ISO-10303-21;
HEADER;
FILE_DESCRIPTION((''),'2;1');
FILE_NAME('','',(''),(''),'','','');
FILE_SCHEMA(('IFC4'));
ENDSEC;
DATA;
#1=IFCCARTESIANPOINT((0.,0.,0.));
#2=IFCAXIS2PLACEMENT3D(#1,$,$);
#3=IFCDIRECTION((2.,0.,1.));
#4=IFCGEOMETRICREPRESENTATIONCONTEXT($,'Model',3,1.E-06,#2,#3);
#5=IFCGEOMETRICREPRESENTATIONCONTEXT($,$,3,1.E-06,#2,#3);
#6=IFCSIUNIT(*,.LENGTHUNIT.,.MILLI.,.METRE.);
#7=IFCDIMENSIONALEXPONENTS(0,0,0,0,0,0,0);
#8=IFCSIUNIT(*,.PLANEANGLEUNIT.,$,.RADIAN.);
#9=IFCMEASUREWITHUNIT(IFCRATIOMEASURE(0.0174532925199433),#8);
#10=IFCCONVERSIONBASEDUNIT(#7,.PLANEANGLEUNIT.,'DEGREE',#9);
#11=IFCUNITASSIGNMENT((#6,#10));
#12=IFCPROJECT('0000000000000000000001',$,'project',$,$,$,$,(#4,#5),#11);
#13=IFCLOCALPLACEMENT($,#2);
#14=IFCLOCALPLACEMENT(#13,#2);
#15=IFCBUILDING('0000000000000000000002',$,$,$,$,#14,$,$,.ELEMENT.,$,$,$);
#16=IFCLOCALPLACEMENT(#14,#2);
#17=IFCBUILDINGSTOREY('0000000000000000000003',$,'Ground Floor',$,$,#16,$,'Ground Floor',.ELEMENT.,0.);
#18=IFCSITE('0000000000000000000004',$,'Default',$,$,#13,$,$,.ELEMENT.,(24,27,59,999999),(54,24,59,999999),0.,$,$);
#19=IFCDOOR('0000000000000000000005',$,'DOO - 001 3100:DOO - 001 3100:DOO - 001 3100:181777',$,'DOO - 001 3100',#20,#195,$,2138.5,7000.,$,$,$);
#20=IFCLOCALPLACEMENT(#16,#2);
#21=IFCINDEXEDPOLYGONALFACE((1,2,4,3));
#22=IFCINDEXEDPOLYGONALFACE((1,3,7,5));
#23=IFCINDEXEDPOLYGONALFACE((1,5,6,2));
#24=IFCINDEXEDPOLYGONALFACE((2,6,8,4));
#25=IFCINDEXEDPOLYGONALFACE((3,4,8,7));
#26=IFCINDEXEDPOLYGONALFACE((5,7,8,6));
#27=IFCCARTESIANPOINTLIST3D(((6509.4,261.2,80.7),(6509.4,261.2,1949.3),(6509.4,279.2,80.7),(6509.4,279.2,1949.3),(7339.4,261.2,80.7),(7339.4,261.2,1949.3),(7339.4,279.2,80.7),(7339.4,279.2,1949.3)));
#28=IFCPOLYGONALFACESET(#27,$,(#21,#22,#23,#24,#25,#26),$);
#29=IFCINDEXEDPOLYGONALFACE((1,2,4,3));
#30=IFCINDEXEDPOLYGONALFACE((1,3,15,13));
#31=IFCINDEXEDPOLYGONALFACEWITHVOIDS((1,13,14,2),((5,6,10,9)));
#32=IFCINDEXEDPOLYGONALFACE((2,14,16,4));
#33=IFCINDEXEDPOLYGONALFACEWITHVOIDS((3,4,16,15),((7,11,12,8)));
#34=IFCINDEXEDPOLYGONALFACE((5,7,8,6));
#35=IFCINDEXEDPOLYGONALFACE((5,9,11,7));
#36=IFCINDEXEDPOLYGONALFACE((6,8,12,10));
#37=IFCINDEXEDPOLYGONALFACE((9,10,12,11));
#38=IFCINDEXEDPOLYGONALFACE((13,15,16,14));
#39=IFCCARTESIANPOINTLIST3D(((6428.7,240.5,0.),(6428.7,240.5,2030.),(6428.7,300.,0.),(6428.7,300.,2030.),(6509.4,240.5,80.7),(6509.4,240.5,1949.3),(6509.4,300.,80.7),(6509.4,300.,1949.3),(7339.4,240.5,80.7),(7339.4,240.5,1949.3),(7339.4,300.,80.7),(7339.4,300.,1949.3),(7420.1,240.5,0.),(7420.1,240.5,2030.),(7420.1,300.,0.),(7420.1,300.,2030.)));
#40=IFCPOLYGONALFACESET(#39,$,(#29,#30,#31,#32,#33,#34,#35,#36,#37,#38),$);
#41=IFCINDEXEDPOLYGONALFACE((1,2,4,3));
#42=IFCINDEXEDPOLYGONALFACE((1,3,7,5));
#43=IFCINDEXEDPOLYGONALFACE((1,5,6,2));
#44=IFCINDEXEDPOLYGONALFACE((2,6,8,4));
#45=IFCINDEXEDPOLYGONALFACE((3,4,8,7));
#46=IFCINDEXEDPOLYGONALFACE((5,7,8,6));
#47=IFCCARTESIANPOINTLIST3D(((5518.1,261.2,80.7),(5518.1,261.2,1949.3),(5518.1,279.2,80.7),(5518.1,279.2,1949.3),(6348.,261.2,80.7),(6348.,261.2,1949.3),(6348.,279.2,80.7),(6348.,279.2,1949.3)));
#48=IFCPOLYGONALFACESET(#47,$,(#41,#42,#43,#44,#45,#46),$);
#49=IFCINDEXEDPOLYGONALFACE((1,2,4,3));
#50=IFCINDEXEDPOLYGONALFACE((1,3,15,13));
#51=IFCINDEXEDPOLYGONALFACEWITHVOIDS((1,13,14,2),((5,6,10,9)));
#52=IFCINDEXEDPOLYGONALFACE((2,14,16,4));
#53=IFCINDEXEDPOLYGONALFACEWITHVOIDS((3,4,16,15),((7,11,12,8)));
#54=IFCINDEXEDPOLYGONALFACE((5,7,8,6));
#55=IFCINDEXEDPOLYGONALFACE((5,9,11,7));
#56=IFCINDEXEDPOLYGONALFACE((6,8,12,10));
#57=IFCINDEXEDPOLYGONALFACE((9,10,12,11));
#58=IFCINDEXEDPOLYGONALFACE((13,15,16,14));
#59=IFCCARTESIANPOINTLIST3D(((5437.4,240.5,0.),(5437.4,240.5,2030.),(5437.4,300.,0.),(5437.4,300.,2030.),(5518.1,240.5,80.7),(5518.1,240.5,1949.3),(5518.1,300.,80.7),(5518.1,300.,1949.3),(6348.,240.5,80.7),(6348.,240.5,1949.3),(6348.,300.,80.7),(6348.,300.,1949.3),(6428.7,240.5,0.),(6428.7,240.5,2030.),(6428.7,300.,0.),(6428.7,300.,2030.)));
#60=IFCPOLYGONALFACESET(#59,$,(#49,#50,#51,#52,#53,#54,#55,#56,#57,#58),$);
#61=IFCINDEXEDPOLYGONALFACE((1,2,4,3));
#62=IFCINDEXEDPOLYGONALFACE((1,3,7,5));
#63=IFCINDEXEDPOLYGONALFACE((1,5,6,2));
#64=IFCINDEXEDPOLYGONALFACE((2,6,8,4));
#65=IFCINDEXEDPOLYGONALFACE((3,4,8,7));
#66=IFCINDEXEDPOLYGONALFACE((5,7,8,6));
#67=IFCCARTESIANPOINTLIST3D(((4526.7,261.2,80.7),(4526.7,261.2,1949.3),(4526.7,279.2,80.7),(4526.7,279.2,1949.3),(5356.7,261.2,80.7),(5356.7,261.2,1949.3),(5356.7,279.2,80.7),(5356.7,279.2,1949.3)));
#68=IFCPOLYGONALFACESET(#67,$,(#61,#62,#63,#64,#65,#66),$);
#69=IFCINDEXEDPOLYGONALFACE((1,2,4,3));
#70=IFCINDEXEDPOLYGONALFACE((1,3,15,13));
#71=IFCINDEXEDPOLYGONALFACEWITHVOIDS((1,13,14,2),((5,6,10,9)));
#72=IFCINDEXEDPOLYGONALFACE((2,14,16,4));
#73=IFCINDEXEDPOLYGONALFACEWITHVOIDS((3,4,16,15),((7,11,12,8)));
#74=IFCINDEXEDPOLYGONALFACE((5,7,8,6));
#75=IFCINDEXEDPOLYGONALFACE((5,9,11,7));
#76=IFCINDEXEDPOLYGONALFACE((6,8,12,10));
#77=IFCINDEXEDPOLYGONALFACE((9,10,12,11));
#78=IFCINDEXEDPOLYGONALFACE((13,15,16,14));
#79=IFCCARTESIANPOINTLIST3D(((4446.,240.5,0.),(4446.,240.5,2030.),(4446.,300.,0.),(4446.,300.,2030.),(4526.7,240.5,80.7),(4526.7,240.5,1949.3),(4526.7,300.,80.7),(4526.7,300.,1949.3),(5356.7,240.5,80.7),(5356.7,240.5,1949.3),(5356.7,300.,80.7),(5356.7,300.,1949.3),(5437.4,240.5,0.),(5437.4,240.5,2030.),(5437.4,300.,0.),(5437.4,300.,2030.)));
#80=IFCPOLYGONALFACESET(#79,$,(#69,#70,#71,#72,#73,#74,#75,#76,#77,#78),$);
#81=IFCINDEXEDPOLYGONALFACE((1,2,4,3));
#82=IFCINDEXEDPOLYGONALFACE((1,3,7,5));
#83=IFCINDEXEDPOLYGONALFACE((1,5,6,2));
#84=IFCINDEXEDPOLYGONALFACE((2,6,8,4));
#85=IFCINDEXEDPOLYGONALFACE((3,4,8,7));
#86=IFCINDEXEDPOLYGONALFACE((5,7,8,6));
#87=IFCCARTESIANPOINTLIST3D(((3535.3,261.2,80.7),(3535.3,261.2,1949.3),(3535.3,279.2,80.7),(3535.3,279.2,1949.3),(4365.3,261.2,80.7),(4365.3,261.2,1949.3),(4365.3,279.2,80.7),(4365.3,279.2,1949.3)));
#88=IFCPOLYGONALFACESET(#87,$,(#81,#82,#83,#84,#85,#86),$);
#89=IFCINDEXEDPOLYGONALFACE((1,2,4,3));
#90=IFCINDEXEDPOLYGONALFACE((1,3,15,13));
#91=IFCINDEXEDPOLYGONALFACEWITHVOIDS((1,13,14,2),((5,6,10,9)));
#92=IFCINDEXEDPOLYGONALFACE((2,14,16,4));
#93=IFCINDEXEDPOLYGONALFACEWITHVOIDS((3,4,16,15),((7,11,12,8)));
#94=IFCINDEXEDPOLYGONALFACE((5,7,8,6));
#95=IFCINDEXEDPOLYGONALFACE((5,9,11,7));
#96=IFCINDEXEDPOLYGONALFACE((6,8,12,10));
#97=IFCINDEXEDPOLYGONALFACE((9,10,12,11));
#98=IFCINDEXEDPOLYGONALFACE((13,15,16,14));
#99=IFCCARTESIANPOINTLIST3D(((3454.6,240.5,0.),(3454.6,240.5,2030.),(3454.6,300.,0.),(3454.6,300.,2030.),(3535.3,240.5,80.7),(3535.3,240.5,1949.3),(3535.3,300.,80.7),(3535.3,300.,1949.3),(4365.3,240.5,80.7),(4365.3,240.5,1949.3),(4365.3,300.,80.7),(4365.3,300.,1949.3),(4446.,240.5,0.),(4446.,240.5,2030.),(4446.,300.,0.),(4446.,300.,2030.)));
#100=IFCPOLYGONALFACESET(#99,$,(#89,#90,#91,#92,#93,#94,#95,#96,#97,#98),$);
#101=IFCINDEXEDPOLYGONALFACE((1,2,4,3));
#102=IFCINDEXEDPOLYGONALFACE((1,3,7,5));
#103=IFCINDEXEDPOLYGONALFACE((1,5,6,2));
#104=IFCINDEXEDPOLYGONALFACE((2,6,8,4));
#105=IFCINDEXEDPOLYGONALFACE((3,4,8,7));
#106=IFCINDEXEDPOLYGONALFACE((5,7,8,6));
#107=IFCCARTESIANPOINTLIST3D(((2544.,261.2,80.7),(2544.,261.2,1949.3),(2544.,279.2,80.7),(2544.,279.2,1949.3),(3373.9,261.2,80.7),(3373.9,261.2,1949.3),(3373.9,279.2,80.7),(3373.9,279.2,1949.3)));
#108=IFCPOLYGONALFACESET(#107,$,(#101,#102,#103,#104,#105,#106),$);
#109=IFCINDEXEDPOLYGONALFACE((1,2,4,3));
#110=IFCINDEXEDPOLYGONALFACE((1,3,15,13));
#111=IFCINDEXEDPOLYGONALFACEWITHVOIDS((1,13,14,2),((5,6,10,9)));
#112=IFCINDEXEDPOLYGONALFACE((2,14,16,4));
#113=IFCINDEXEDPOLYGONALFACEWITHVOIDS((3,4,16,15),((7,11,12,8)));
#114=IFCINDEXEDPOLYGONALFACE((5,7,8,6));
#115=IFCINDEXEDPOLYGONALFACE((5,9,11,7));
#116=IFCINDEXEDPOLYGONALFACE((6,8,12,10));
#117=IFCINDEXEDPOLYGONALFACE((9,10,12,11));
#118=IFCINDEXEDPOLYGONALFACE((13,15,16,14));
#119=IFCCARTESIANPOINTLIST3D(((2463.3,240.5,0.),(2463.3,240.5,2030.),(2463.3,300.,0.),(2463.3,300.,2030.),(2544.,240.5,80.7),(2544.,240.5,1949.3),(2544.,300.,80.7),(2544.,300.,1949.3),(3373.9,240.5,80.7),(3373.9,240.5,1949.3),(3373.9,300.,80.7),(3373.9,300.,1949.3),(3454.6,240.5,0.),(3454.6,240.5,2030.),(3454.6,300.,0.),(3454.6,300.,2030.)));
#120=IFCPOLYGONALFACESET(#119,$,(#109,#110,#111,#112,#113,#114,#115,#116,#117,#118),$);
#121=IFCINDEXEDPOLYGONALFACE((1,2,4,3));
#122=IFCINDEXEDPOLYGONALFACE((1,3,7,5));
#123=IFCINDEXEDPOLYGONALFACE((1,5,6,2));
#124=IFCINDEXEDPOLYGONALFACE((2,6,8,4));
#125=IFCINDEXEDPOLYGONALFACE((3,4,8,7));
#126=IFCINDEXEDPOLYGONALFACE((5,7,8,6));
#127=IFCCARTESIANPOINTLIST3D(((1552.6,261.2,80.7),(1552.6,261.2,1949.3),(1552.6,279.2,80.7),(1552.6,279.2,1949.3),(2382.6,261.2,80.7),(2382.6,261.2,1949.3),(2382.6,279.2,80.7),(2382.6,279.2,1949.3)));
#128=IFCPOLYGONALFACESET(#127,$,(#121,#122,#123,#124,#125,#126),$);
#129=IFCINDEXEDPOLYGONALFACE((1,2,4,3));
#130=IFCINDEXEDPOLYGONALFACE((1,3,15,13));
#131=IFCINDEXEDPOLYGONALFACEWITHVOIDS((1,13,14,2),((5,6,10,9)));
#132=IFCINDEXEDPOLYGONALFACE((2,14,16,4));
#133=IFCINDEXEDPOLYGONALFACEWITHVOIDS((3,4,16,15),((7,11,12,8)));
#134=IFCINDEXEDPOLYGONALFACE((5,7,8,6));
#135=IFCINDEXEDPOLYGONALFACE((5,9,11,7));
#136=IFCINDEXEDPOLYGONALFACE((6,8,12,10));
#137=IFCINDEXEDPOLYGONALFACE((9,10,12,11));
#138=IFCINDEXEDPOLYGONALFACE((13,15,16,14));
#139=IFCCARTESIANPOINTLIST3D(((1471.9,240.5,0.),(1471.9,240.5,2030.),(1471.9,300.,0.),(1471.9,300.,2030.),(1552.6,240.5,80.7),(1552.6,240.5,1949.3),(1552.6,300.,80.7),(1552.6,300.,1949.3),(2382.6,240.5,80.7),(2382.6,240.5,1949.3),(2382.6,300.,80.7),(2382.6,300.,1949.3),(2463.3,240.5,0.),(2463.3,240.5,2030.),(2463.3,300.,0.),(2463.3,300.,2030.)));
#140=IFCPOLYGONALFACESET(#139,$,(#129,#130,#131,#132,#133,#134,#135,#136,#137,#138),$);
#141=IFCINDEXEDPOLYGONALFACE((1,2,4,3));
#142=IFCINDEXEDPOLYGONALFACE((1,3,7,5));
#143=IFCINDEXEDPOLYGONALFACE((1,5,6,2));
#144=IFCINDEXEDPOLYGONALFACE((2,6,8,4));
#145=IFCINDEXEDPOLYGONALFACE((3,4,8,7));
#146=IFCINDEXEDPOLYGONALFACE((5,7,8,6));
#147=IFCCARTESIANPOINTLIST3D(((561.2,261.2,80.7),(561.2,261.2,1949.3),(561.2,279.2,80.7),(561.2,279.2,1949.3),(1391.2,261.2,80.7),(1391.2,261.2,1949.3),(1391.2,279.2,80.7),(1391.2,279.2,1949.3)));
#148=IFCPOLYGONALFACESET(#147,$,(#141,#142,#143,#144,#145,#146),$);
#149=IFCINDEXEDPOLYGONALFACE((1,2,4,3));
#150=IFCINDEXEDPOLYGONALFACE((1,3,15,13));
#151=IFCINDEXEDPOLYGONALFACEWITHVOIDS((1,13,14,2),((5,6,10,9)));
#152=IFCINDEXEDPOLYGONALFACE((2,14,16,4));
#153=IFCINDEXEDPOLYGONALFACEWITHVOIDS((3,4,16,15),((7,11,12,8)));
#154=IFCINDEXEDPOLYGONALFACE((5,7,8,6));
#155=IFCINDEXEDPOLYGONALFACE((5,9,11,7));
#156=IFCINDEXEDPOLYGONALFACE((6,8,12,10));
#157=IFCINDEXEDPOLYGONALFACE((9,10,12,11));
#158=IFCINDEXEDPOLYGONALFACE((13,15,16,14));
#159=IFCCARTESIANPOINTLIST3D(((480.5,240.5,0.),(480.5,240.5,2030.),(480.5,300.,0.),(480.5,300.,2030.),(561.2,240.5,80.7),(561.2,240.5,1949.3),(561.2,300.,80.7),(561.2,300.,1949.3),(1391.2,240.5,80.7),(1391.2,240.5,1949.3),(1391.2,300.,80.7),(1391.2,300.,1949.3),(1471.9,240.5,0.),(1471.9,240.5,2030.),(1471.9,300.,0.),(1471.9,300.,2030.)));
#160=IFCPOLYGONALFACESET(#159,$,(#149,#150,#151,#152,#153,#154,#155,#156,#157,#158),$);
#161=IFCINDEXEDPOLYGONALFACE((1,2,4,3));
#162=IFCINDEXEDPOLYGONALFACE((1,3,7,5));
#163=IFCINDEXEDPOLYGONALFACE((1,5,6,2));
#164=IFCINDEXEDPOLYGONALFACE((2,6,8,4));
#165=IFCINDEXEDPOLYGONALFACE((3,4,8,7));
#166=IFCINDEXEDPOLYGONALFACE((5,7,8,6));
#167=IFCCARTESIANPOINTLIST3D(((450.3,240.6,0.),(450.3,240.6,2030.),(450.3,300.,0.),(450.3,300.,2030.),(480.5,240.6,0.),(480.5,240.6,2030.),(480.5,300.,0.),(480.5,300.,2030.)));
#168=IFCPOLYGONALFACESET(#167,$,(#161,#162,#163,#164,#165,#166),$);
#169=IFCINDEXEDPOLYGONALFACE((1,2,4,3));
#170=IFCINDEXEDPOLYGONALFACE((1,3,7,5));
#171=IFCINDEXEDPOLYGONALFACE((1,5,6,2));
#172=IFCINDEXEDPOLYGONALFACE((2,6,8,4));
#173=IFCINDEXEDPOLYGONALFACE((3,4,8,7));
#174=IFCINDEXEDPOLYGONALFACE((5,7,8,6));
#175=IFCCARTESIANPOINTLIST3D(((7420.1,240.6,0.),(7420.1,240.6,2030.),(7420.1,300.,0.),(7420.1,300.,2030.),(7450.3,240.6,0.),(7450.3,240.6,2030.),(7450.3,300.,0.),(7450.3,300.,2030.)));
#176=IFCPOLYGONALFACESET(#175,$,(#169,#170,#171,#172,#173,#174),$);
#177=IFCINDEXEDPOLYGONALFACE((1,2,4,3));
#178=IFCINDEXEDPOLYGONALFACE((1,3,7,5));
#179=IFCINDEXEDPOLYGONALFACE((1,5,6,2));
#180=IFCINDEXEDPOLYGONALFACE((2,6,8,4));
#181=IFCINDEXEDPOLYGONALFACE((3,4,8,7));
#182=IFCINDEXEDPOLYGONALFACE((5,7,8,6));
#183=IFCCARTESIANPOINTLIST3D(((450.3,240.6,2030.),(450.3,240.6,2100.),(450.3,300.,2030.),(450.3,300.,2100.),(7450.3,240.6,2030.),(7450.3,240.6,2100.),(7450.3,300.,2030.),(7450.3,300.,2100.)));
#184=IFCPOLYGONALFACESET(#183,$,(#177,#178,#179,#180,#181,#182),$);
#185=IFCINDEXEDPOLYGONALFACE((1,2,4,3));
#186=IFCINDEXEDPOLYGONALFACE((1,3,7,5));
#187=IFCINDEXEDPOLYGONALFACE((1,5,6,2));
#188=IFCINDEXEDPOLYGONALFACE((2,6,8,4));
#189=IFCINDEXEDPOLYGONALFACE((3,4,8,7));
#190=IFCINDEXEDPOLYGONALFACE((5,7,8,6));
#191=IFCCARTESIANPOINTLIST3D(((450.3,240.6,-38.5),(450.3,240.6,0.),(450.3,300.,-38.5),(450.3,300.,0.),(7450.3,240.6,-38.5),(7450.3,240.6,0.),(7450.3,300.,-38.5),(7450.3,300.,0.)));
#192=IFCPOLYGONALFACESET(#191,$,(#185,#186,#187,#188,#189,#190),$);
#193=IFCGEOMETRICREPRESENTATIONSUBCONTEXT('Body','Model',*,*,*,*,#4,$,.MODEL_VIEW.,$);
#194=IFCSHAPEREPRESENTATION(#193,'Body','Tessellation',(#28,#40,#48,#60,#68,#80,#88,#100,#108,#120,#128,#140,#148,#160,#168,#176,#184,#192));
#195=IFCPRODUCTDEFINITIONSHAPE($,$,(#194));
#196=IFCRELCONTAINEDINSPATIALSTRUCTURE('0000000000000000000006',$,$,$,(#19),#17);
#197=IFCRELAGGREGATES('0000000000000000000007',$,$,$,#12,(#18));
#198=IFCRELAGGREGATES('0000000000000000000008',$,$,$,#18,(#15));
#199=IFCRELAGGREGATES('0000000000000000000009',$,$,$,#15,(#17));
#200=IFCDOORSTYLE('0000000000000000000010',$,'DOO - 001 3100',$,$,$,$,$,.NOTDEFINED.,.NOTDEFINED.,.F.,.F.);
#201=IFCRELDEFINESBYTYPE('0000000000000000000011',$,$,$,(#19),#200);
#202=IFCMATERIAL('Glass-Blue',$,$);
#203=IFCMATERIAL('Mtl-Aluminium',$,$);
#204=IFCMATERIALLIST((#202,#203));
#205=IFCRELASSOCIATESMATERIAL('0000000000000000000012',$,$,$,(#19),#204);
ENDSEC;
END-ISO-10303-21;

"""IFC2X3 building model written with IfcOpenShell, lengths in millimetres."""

from ifc_helpers import new_model, entity, si_unit, converted_unit, direction, frame, frame_2d, origin, origin_2d_with_axis, place, context, subcontext, project, spatial, polyline, rectangle, outline, extrude, source, transform, mapped, material, material_list, type_object, type_shapes, element, save


model = new_model("IFC2X3")

# Units and contexts
model_context = context("Model", 3, precision=1e-06, world=origin(), true_north=direction((2.0, 0.0, 1.0)))
context_of_model = context(None, 3, precision=1e-06, world=origin(), true_north=direction((2.0, 0.0, 1.0)))
body_context = subcontext(model_context, "Body", "Model", "MODEL_VIEW")
ifc_project = project(units=[si_unit("LENGTHUNIT", "METRE", prefix="MILLI"), converted_unit("PLANEANGLEUNIT", "DEGREE", entity("IfcRatioMeasure", 0.0174532925199433), si_unit("PLANEANGLEUNIT", "RADIAN"), dimensions=[0, 0, 0, 0, 0, 0, 0])], contexts=[model_context, context_of_model])

# Site, building, storey
site_placement = place(None, origin())
site = spatial("IfcSite", under=ifc_project, at=site_placement, Name="Default", CompositionType="ELEMENT", RefLatitude=(24, 27, 59, 999999), RefLongitude=(54, 24, 59, 999999), RefElevation=0.0)
building_placement = place(site_placement, origin())
building = spatial("IfcBuilding", under=site, at=building_placement, CompositionType="ELEMENT")
storey_placement = place(building_placement, origin())
storey = spatial("IfcBuildingStorey", under=building, at=storey_placement, Name="Ground Floor", LongName="Ground Floor", CompositionType="ELEMENT", Elevation=0.0)

# Door
ifc_material_1 = material(Name="Glass-Blue")
ifc_material_2 = material(Name="Mtl-Aluminium")
ifc_material_list = material_list([ifc_material_1, ifc_material_2])
door_style = type_object("IfcDoorStyle", Name="DOO - 001 3100", ConstructionType="NOTDEFINED", OperationType="NOTDEFINED", ParameterTakesPrecedence=False, Sizeable=False)
shared_shape = source(origin(), body_context, "Body", "SweptSolid", [
    extrude(rectangle(XDim=830.0, YDim=18.0, at=frame_2d((0.0, 0.0), x_axis=(1.0, 0.0))), frame((6924.4, 270.2, 80.7), z_axis=(0.0, 0.0, 1.0), x_axis=(-1.0, 0.0, 0.0)), (0.0, 0.0, 1.0), 1868.6),
    extrude(outline(polyline([(-495.7, -1015.0), (495.7, -1015.0), (495.7, 1015.0), (-495.7, 1015.0), (-495.7, -1015.0)]), holes=[polyline([(415.0, 934.3), (415.0, -934.3), (-415.0, -934.3), (-415.0, 934.3), (415.0, 934.3)])]), frame((6924.4, 240.5, 1015.0), z_axis=(0.0, 1.0, 0.0), x_axis=(-1.0, 0.0, 0.0)), (0.0, 0.0, 1.0), 59.5),
    extrude(rectangle(XDim=830.0, YDim=18.0, at=frame_2d((0.0, 0.0), x_axis=(1.0, 0.0))), frame((5933.1, 270.2, 80.7), z_axis=(0.0, 0.0, 1.0), x_axis=(-1.0, 0.0, 0.0)), (0.0, 0.0, 1.0), 1868.6),
    extrude(outline(polyline([(-495.7, -1015.0), (495.7, -1015.0), (495.7, 1015.0), (-495.7, 1015.0), (-495.7, -1015.0)]), holes=[polyline([(415.0, 934.3), (415.0, -934.3), (-415.0, -934.3), (-415.0, 934.3), (415.0, 934.3)])]), frame((5933.1, 240.5, 1015.0), z_axis=(0.0, 1.0, 0.0), x_axis=(-1.0, 0.0, 0.0)), (0.0, 0.0, 1.0), 59.5),
    extrude(rectangle(XDim=830.0, YDim=18.0, at=frame_2d((0.0, 0.0), x_axis=(1.0, 0.0))), frame((4941.7, 270.2, 80.7), z_axis=(0.0, 0.0, 1.0), x_axis=(-1.0, 0.0, 0.0)), (0.0, 0.0, 1.0), 1868.6),
    extrude(outline(polyline([(-495.7, -1015.0), (495.7, -1015.0), (495.7, 1015.0), (-495.7, 1015.0), (-495.7, -1015.0)]), holes=[polyline([(415.0, 934.3), (415.0, -934.3), (-415.0, -934.3), (-415.0, 934.3), (415.0, 934.3)])]), frame((4941.7, 240.5, 1015.0), z_axis=(0.0, 1.0, 0.0), x_axis=(-1.0, 0.0, 0.0)), (0.0, 0.0, 1.0), 59.5),
    extrude(rectangle(XDim=830.0, YDim=18.0, at=frame_2d((0.0, 0.0), x_axis=(1.0, 0.0))), frame((3950.3, 270.2, 80.7), z_axis=(0.0, 0.0, 1.0), x_axis=(-1.0, 0.0, 0.0)), (0.0, 0.0, 1.0), 1868.6),
    extrude(outline(polyline([(-495.7, -1015.0), (495.7, -1015.0), (495.7, 1015.0), (-495.7, 1015.0), (-495.7, -1015.0)]), holes=[polyline([(415.0, 934.3), (415.0, -934.3), (-415.0, -934.3), (-415.0, 934.3), (415.0, 934.3)])]), frame((3950.3, 240.5, 1015.0), z_axis=(0.0, 1.0, 0.0), x_axis=(-1.0, 0.0, 0.0)), (0.0, 0.0, 1.0), 59.5),
    extrude(rectangle(XDim=830.0, YDim=18.0, at=frame_2d((0.0, 0.0), x_axis=(1.0, 0.0))), frame((2958.9, 270.2, 80.7), z_axis=(0.0, 0.0, 1.0), x_axis=(-1.0, 0.0, 0.0)), (0.0, 0.0, 1.0), 1868.6),
    extrude(outline(polyline([(-495.7, -1015.0), (495.7, -1015.0), (495.7, 1015.0), (-495.7, 1015.0), (-495.7, -1015.0)]), holes=[polyline([(415.0, 934.3), (415.0, -934.3), (-415.0, -934.3), (-415.0, 934.3), (415.0, 934.3)])]), frame((2958.9, 240.5, 1015.0), z_axis=(0.0, 1.0, 0.0), x_axis=(-1.0, 0.0, 0.0)), (0.0, 0.0, 1.0), 59.5),
    extrude(rectangle(XDim=830.0, YDim=18.0, at=frame_2d((0.0, 0.0), x_axis=(1.0, 0.0))), frame((1967.6, 270.2, 80.7), z_axis=(0.0, 0.0, 1.0), x_axis=(-1.0, 0.0, 0.0)), (0.0, 0.0, 1.0), 1868.6),
    extrude(outline(polyline([(-495.7, -1015.0), (495.7, -1015.0), (495.7, 1015.0), (-495.7, 1015.0), (-495.7, -1015.0)]), holes=[polyline([(415.0, 934.3), (415.0, -934.3), (-415.0, -934.3), (-415.0, 934.3), (415.0, 934.3)])]), frame((1967.6, 240.5, 1015.0), z_axis=(0.0, 1.0, 0.0), x_axis=(-1.0, 0.0, 0.0)), (0.0, 0.0, 1.0), 59.5),
    extrude(rectangle(XDim=830.0, YDim=18.0, at=frame_2d((0.0, 0.0), x_axis=(1.0, 0.0))), frame((976.2, 270.2, 80.7), z_axis=(0.0, 0.0, 1.0), x_axis=(-1.0, 0.0, 0.0)), (0.0, 0.0, 1.0), 1868.6),
    extrude(outline(polyline([(-495.7, -1015.0), (495.7, -1015.0), (495.7, 1015.0), (-495.7, 1015.0), (-495.7, -1015.0)]), holes=[polyline([(415.0, 934.3), (415.0, -934.3), (-415.0, -934.3), (-415.0, 934.3), (415.0, 934.3)])]), frame((976.2, 240.5, 1015.0), z_axis=(0.0, 1.0, 0.0), x_axis=(-1.0, 0.0, 0.0)), (0.0, 0.0, 1.0), 59.5),
    extrude(rectangle(XDim=30.2, YDim=59.4, at=frame_2d((0.0, 0.0), x_axis=(1.0, 0.0))), frame((465.4, 270.3, 0.0), z_axis=(0.0, 0.0, 1.0), x_axis=(-1.0, 0.0, 0.0)), (0.0, 0.0, 1.0), 2030.0),
    extrude(rectangle(XDim=30.2, YDim=59.4, at=origin_2d_with_axis()), frame((7435.2, 270.3, 0.0), z_axis=(0.0, 0.0, 1.0), x_axis=(-1.0, 0.0, 0.0)), (0.0, 0.0, 1.0), 2030.0),
    extrude(rectangle(XDim=7000.0, YDim=59.4, at=origin_2d_with_axis()), frame((3950.3, 270.3, 2030.0), z_axis=(0.0, 0.0, 1.0), x_axis=(-1.0, 0.0, 0.0)), (0.0, 0.0, 1.0), 70.0),
    extrude(rectangle(XDim=7000.0, YDim=59.4, at=origin_2d_with_axis()), frame((3950.3, 270.3, -38.5), z_axis=(0.0, 0.0, 1.0), x_axis=(-1.0, 0.0, 0.0)), (0.0, 0.0, 1.0), 38.5),
])
type_shapes(door_style, [shared_shape])
door_placement = place(storey_placement, origin())
element("IfcDoor", 1, at=door_placement, inside=storey, type_object=door_style, material=ifc_material_list, Name="DOO - 001 3100:DOO - 001 3100:DOO - 001 3100:181777", ObjectType="DOO - 001 3100", OverallHeight=2138.5, OverallWidth=7000.0, context=body_context, shape_type="MappedRepresentation", body=[
    mapped(shared_shape, transform((0.0, 0.0, 0.0), scale=1.0)),
])

save(model, "model.ifc")
